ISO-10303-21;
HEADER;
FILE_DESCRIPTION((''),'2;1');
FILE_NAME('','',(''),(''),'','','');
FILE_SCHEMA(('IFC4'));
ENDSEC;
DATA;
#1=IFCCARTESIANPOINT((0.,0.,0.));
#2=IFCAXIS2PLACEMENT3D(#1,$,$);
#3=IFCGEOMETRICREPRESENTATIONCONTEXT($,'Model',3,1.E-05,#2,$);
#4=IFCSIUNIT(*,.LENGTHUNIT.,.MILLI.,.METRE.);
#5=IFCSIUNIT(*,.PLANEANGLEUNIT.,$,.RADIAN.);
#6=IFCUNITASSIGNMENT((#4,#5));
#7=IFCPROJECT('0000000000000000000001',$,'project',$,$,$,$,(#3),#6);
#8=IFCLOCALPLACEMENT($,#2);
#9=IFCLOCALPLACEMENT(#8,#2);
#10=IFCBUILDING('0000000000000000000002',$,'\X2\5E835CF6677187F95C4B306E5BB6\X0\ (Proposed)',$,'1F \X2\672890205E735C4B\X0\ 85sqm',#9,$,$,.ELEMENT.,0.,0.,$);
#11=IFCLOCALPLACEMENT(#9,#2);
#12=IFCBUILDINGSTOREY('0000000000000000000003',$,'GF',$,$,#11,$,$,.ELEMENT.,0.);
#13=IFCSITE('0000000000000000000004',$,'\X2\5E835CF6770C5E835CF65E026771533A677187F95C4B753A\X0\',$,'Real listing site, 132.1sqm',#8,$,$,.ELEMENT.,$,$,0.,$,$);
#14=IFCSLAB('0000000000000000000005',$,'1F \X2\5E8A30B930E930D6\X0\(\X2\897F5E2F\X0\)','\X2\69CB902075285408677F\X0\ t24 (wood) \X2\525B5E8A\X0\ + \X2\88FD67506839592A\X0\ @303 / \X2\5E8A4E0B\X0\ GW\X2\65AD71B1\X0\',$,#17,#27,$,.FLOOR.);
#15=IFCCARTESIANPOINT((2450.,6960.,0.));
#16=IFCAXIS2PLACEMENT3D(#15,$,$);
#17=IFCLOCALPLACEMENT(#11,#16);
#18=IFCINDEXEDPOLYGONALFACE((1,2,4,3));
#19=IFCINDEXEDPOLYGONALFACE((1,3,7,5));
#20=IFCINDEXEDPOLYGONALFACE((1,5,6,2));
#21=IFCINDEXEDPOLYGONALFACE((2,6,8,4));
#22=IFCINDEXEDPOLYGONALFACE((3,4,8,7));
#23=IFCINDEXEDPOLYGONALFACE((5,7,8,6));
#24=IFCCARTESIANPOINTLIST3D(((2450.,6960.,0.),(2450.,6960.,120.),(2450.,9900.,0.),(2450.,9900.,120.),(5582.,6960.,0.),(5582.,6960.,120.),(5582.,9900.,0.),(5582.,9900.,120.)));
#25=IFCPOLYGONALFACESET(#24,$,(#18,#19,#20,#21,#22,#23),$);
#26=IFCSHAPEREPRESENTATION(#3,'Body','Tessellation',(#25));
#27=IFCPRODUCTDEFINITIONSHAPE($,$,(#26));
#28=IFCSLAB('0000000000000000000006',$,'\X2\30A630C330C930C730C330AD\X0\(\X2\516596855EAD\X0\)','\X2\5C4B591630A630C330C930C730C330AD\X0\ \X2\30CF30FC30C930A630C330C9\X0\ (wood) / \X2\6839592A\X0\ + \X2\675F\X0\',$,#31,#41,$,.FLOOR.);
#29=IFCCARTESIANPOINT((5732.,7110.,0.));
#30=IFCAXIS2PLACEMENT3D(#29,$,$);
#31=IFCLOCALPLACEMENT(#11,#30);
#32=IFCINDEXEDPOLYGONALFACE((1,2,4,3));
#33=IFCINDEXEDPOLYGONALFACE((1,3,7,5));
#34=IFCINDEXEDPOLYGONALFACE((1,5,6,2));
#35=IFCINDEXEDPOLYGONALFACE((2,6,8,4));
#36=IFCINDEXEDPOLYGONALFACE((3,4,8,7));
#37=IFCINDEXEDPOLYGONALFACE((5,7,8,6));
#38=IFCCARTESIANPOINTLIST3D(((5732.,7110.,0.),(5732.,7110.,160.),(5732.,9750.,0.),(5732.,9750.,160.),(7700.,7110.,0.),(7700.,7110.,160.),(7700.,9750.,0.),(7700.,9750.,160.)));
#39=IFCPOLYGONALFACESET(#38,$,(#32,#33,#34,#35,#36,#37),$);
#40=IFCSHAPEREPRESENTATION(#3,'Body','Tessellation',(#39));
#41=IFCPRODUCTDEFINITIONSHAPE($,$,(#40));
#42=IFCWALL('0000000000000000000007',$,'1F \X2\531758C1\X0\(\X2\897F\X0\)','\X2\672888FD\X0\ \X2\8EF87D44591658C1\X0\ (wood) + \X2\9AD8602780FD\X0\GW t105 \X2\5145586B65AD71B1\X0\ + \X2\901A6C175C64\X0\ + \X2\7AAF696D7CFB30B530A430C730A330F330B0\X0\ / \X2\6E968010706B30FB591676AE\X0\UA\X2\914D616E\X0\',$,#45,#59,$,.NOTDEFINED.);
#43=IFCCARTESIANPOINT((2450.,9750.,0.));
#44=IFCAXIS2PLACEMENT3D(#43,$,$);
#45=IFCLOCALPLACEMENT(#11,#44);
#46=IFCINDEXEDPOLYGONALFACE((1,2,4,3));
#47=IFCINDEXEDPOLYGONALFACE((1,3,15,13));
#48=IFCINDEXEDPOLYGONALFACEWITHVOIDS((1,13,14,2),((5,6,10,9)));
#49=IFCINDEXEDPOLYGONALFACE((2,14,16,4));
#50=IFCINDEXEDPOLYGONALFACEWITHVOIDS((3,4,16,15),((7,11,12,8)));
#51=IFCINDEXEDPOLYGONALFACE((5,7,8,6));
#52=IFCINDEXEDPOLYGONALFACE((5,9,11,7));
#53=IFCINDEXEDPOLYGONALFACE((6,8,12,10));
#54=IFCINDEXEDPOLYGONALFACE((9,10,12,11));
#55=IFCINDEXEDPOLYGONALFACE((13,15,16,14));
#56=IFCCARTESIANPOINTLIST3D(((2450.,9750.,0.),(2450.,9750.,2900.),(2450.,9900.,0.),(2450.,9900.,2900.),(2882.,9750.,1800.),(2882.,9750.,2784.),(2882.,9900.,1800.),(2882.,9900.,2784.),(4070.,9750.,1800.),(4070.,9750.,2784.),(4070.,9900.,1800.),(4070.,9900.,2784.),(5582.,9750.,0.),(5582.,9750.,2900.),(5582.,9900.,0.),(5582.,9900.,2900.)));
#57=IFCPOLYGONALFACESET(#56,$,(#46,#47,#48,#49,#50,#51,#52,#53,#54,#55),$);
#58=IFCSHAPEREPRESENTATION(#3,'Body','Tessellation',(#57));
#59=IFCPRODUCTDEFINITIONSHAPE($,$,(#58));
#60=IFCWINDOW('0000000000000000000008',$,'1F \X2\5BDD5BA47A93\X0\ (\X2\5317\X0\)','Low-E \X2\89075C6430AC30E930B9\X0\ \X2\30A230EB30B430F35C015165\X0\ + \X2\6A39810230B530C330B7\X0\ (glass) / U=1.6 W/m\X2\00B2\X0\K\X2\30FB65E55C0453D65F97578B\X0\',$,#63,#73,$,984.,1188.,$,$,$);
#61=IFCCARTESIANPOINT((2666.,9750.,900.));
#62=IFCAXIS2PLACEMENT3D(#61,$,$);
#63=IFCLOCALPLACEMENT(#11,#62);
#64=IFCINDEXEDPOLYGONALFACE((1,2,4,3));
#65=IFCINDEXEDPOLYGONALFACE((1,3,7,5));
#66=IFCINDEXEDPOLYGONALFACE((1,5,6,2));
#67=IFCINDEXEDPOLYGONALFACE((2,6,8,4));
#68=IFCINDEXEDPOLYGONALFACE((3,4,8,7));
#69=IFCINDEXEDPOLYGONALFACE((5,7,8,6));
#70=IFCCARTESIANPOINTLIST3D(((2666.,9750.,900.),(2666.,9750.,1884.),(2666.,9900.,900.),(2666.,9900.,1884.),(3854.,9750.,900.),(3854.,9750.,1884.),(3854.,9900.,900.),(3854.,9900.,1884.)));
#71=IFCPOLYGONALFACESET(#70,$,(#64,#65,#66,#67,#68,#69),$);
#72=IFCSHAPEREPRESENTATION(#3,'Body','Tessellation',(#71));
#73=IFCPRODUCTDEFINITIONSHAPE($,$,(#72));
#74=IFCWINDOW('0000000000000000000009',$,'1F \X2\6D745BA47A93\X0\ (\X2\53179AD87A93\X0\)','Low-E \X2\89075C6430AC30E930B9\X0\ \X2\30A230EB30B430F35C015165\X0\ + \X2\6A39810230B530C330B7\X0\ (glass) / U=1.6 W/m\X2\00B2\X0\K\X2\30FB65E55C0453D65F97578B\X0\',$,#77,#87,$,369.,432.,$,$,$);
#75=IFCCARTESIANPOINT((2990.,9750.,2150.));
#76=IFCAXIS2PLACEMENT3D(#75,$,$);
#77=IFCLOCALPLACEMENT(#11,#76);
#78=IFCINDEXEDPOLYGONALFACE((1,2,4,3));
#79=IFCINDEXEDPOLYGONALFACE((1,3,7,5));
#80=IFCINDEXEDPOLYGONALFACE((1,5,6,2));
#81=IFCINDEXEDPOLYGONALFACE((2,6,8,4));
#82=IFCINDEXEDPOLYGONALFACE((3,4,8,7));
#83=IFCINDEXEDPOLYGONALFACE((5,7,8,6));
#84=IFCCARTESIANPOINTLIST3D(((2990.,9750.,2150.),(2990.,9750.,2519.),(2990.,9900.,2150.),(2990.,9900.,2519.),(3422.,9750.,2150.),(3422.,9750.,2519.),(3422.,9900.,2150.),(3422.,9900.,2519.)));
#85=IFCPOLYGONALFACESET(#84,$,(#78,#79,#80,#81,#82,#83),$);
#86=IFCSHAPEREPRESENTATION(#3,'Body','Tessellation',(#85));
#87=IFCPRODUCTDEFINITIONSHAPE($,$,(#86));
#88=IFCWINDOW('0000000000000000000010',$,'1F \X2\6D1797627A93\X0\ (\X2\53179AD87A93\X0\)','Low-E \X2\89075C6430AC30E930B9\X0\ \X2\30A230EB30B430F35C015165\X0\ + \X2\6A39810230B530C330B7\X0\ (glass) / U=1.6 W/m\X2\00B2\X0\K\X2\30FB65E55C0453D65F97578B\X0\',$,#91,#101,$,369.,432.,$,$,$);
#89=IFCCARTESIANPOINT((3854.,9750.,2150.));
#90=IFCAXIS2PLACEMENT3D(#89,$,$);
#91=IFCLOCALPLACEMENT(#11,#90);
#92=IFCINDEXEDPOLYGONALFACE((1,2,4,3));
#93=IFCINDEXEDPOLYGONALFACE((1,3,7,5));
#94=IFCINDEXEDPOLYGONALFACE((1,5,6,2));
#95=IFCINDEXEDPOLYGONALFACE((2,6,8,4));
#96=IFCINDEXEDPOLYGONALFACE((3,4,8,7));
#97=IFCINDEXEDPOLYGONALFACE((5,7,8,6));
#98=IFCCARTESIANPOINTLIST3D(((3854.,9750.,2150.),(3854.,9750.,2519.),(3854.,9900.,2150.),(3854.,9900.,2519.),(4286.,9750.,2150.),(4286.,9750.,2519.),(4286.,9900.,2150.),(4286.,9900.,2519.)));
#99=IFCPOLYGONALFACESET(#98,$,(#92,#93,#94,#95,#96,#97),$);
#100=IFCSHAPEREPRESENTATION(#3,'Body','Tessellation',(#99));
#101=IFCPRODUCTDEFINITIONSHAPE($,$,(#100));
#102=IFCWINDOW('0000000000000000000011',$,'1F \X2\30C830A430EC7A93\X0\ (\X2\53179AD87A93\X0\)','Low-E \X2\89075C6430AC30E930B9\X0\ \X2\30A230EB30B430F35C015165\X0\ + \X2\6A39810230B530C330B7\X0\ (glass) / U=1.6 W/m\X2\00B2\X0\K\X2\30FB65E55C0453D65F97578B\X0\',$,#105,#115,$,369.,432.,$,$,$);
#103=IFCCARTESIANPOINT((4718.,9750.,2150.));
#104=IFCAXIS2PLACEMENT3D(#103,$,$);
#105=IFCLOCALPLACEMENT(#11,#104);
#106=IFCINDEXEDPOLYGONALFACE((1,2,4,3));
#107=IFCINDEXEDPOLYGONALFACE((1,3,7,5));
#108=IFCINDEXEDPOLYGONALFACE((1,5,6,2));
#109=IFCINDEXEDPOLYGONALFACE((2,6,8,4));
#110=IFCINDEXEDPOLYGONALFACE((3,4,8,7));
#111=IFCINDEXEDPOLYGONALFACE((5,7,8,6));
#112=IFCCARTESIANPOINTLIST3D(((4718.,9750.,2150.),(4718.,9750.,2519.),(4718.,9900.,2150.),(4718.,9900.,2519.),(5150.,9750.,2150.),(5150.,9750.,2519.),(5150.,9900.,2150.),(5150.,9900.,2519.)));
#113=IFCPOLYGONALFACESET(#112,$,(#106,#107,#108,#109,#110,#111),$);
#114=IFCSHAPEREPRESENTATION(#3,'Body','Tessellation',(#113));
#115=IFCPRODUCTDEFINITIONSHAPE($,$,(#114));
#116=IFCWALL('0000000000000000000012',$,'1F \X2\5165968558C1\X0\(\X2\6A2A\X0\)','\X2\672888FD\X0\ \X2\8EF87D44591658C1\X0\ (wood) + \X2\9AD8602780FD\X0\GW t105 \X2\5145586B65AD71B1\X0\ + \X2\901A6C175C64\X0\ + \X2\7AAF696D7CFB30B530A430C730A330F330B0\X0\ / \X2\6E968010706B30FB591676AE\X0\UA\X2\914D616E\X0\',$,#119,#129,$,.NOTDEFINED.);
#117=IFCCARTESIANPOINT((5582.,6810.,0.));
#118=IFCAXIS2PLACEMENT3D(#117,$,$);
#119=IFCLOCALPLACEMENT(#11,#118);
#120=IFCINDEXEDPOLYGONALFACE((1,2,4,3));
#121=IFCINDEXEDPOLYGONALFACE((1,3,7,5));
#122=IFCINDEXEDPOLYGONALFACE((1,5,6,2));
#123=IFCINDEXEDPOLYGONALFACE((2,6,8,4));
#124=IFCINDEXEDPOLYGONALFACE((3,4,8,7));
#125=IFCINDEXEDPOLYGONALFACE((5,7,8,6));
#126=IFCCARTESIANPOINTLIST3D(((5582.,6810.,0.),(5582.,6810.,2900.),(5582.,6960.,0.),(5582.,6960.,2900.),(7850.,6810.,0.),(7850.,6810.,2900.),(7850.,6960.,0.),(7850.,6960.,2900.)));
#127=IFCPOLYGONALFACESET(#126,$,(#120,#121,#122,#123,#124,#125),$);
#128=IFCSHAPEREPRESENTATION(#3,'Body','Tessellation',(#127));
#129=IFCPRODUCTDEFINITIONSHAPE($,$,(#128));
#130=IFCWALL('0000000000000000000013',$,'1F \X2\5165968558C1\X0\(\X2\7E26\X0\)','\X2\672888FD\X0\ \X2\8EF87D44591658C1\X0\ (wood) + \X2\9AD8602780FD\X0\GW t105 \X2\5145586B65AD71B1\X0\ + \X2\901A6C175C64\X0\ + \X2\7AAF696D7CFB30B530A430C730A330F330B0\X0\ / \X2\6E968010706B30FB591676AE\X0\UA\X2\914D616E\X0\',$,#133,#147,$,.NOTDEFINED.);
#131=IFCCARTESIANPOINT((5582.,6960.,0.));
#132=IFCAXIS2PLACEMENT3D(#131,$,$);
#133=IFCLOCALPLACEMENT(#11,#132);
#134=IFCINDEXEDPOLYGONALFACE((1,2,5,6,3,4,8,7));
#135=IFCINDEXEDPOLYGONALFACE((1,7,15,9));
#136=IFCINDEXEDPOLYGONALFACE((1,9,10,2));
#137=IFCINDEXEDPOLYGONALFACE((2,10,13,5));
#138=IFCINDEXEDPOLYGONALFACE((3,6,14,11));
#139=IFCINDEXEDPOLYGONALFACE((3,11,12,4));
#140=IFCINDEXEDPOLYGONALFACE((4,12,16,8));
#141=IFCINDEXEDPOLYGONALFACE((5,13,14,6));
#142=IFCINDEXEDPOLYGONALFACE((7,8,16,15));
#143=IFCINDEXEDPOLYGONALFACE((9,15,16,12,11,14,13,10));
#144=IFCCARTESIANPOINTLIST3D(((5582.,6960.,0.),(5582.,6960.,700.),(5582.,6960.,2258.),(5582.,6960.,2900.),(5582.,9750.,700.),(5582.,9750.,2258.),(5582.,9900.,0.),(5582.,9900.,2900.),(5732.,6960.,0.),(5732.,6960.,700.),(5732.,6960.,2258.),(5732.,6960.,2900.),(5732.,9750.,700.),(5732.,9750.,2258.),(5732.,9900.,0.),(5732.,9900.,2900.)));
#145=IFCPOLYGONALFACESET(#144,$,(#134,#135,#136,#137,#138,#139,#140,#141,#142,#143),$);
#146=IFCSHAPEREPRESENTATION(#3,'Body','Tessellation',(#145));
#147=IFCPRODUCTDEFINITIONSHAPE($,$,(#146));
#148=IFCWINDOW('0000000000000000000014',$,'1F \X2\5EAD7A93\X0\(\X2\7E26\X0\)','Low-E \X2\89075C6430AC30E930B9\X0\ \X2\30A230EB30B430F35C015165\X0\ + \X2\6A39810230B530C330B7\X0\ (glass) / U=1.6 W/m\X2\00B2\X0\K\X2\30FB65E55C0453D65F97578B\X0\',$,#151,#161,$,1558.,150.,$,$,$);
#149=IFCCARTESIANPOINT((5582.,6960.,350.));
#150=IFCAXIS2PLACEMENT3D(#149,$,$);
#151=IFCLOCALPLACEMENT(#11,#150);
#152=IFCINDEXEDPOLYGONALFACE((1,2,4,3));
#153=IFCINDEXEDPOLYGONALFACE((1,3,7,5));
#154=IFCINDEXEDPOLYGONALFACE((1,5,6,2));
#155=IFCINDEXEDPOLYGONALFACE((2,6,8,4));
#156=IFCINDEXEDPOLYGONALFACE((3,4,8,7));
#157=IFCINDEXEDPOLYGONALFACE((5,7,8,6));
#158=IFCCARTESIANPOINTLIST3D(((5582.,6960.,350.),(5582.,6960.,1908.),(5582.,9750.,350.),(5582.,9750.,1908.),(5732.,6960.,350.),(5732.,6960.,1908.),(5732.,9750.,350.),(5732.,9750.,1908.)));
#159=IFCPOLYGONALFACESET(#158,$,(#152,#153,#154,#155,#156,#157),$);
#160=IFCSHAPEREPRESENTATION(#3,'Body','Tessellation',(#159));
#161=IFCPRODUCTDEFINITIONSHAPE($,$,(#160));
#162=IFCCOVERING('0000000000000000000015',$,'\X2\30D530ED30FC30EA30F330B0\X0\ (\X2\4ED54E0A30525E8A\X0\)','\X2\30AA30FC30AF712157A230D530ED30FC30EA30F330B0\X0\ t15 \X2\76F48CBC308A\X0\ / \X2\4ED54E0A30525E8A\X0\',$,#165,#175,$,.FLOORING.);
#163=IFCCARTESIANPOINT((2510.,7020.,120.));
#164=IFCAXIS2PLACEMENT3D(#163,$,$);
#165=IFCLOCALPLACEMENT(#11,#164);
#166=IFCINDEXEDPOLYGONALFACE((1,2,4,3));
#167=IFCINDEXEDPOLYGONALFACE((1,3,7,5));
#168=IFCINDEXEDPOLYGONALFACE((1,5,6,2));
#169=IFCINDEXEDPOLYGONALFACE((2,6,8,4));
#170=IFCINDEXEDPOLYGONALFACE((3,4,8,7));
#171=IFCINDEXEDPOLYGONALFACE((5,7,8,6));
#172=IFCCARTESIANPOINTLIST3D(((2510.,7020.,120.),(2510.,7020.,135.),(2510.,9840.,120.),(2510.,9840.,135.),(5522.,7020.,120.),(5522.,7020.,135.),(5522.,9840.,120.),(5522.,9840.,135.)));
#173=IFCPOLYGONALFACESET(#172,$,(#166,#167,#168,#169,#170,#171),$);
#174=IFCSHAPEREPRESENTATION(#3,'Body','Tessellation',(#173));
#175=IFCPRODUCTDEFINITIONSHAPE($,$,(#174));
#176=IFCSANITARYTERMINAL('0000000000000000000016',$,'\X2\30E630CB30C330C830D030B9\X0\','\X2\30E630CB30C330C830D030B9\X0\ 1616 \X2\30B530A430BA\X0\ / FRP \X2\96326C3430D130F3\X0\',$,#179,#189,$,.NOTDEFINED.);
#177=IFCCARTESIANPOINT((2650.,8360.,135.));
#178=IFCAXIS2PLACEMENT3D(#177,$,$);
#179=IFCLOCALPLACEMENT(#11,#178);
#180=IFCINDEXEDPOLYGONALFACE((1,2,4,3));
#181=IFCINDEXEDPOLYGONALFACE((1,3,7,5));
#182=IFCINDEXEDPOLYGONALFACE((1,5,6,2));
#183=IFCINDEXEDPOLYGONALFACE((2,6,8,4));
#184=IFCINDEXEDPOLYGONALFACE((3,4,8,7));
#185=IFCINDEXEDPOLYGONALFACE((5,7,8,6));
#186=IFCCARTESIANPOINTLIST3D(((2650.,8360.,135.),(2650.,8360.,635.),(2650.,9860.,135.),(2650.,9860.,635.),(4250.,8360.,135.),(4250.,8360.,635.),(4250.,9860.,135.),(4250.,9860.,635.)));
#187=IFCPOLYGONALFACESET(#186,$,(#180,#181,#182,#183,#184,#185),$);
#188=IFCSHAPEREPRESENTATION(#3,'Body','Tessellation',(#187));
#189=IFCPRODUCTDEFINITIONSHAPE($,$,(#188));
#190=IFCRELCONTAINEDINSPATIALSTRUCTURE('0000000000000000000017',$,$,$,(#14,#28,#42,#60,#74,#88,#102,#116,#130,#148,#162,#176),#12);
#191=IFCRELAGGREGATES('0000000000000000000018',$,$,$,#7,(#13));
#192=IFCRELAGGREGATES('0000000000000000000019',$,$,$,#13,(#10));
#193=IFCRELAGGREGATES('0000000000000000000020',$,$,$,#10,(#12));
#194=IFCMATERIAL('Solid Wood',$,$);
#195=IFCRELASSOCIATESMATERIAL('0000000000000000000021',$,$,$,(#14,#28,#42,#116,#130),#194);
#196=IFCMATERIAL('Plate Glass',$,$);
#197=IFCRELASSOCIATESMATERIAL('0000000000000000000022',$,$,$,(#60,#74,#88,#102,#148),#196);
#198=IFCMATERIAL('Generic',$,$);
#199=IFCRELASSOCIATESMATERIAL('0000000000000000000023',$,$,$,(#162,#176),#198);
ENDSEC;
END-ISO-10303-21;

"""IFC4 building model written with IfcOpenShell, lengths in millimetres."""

from ifc_helpers import new_model, si_unit, frame, frame_2d, origin, place, context, project, spatial, rectangle, extrude, material, element, fill, save


model = new_model("IFC4")

# Units and contexts
model_context = context("Model", 3, precision=1e-05, world=origin())
ifc_project = project(units=[si_unit("LENGTHUNIT", "METRE", prefix="MILLI"), si_unit("PLANEANGLEUNIT", "RADIAN")], contexts=[model_context])

# Site, building, storey
site_placement = place(None, origin())
site = spatial("IfcSite", under=ifc_project, at=site_placement, Name="広島県広島市東区東蟹屋町", ObjectType="Real listing site, 132.1sqm", CompositionType="ELEMENT", RefElevation=0.0)
building_placement = place(site_placement, origin())
building = spatial("IfcBuilding", under=site, at=building_placement, Name="広島東蟹屋の家 (Proposed)", ObjectType="1F 木造平屋 85sqm", CompositionType="ELEMENT", ElevationOfRefHeight=0.0, ElevationOfTerrain=0.0)
storey_placement = place(building_placement, origin())
storey = spatial("IfcBuildingStorey", under=building, at=storey_placement, Name="GF", CompositionType="ELEMENT", Elevation=0.0)

# Slabs
ifc_material_1 = material(Name="Solid Wood")
slab_1_placement = place(storey_placement, frame((2450.0, 6960.0, 0.0)))
element("IfcSlab", 1, at=slab_1_placement, inside=storey, material=ifc_material_1, Name="1F 床スラブ(西帯)", Description="構造用合板 t24 (wood) 剛床 + 製材根太 @303 / 床下 GW断熱", PredefinedType="FLOOR", context=model_context, shape_type="SweptSolid", body=[
    extrude(rectangle(XDim=3132.0, YDim=2940.0, at=frame_2d((1566.0, 1470.0))), frame((2450.0, 6960.0, 0.0)), (0.0, 0.0, 1.0), 120.0),
])
slab_2_placement = place(storey_placement, frame((5732.0, 7110.0, 0.0)))
element("IfcSlab", 2, at=slab_2_placement, inside=storey, material=ifc_material_1, Name="ウッドデッキ(入隅庭)", Description="屋外ウッドデッキ ハードウッド (wood) / 根太 + 束", PredefinedType="FLOOR", context=model_context, shape_type="SweptSolid", body=[
    extrude(rectangle(XDim=1968.0, YDim=2640.0, at=frame_2d((984.0, 1320.0))), frame((5732.0, 7110.0, 0.0)), (0.0, 0.0, 1.0), 160.0),
])

# Wall, openings, windows
wall_1_placement = place(storey_placement, frame((2450.0, 9750.0, 0.0)))
wall_1 = element("IfcWall", 3, at=wall_1_placement, inside=storey, material=ifc_material_1, Name="1F 北壁(西)", Description="木製 軸組外壁 (wood) + 高性能GW t105 充填断熱 + 通気層 + 窯業系サイディング / 準耐火・外皮UA配慮", PredefinedType="NOTDEFINED", context=model_context, shape_type="SweptSolid", body=[
    extrude(rectangle(XDim=3132.0, YDim=150.0, at=frame_2d((1566.0, 75.0))), frame((2450.0, 9750.0, 0.0)), (0.0, 0.0, 1.0), 2900.0),
])
opening_1_placement = place(storey_placement, frame((2666.0, 9750.0, 900.0)))
opening_1 = element("IfcOpeningElement", 4, at=opening_1_placement, cuts=wall_1, PredefinedType="NOTDEFINED", context=model_context, shape_type="SweptSolid", body=[
    extrude(rectangle(XDim=1188.0, YDim=150.0, at=frame_2d((594.0, 75.0))), frame((2666.0, 9750.0, 900.0)), (0.0, 0.0, 1.0), 984.0),
])
opening_2_placement = place(storey_placement, frame((2990.0, 9750.0, 2150.0)))
opening_2 = element("IfcOpeningElement", 5, at=opening_2_placement, cuts=wall_1, PredefinedType="NOTDEFINED", context=model_context, shape_type="SweptSolid", body=[
    extrude(rectangle(XDim=432.0, YDim=150.0, at=frame_2d((216.0, 75.0))), frame((2990.0, 9750.0, 2150.0)), (0.0, 0.0, 1.0), 369.0),
])
opening_3_placement = place(storey_placement, frame((3854.0, 9750.0, 2150.0)))
opening_3 = element("IfcOpeningElement", 6, at=opening_3_placement, cuts=wall_1, PredefinedType="NOTDEFINED", context=model_context, shape_type="SweptSolid", body=[
    extrude(rectangle(XDim=432.0, YDim=150.0, at=frame_2d((216.0, 75.0))), frame((3854.0, 9750.0, 2150.0)), (0.0, 0.0, 1.0), 369.0),
])
opening_4_placement = place(storey_placement, frame((4718.0, 9750.0, 2150.0)))
opening_4 = element("IfcOpeningElement", 7, at=opening_4_placement, cuts=wall_1, PredefinedType="NOTDEFINED", context=model_context, shape_type="SweptSolid", body=[
    extrude(rectangle(XDim=432.0, YDim=150.0, at=frame_2d((216.0, 75.0))), frame((4718.0, 9750.0, 2150.0)), (0.0, 0.0, 1.0), 369.0),
])
ifc_material_2 = material(Name="Plate Glass")
window_1_placement = place(storey_placement, frame((2666.0, 9750.0, 900.0)))
window_1 = element("IfcWindow", 8, at=window_1_placement, inside=storey, material=ifc_material_2, Name="1F 寝室窓 (北)", Description="Low-E 複層ガラス アルゴン封入 + 樹脂サッシ (glass) / U=1.6 W/m²K・日射取得型", OverallHeight=984.0, OverallWidth=1188.0, context=model_context, shape_type="SweptSolid", body=[
    extrude(rectangle(XDim=1188.0, YDim=150.0, at=frame_2d((594.0, 75.0))), frame((2666.0, 9750.0, 900.0)), (0.0, 0.0, 1.0), 984.0),
])
fill(opening_1, window_1)
window_2_placement = place(storey_placement, frame((2990.0, 9750.0, 2150.0)))
window_2 = element("IfcWindow", 9, at=window_2_placement, inside=storey, material=ifc_material_2, Name="1F 浴室窓 (北高窓)", Description="Low-E 複層ガラス アルゴン封入 + 樹脂サッシ (glass) / U=1.6 W/m²K・日射取得型", OverallHeight=369.0, OverallWidth=432.0, context=model_context, shape_type="SweptSolid", body=[
    extrude(rectangle(XDim=432.0, YDim=150.0, at=frame_2d((216.0, 75.0))), frame((2990.0, 9750.0, 2150.0)), (0.0, 0.0, 1.0), 369.0),
])
fill(opening_2, window_2)
window_3_placement = place(storey_placement, frame((3854.0, 9750.0, 2150.0)))
window_3 = element("IfcWindow", 10, at=window_3_placement, inside=storey, material=ifc_material_2, Name="1F 洗面窓 (北高窓)", Description="Low-E 複層ガラス アルゴン封入 + 樹脂サッシ (glass) / U=1.6 W/m²K・日射取得型", OverallHeight=369.0, OverallWidth=432.0, context=model_context, shape_type="SweptSolid", body=[
    extrude(rectangle(XDim=432.0, YDim=150.0, at=frame_2d((216.0, 75.0))), frame((3854.0, 9750.0, 2150.0)), (0.0, 0.0, 1.0), 369.0),
])
fill(opening_3, window_3)
window_4_placement = place(storey_placement, frame((4718.0, 9750.0, 2150.0)))
window_4 = element("IfcWindow", 11, at=window_4_placement, inside=storey, material=ifc_material_2, Name="1F トイレ窓 (北高窓)", Description="Low-E 複層ガラス アルゴン封入 + 樹脂サッシ (glass) / U=1.6 W/m²K・日射取得型", OverallHeight=369.0, OverallWidth=432.0, context=model_context, shape_type="SweptSolid", body=[
    extrude(rectangle(XDim=432.0, YDim=150.0, at=frame_2d((216.0, 75.0))), frame((4718.0, 9750.0, 2150.0)), (0.0, 0.0, 1.0), 369.0),
])
fill(opening_4, window_4)

# Wall
wall_2_placement = place(storey_placement, frame((5582.0, 6810.0, 0.0)))
element("IfcWall", 12, at=wall_2_placement, inside=storey, material=ifc_material_1, Name="1F 入隅壁(横)", Description="木製 軸組外壁 (wood) + 高性能GW t105 充填断熱 + 通気層 + 窯業系サイディング / 準耐火・外皮UA配慮", PredefinedType="NOTDEFINED", context=model_context, shape_type="SweptSolid", body=[
    extrude(rectangle(XDim=2268.0, YDim=150.0, at=frame_2d((1134.0, 75.0))), frame((5582.0, 6810.0, 0.0)), (0.0, 0.0, 1.0), 2900.0),
])

# Wall, opening, window
wall_3_placement = place(storey_placement, frame((5582.0, 6960.0, 0.0)))
wall_3 = element("IfcWall", 13, at=wall_3_placement, inside=storey, material=ifc_material_1, Name="1F 入隅壁(縦)", Description="木製 軸組外壁 (wood) + 高性能GW t105 充填断熱 + 通気層 + 窯業系サイディング / 準耐火・外皮UA配慮", PredefinedType="NOTDEFINED", context=model_context, shape_type="SweptSolid", body=[
    extrude(rectangle(XDim=150.0, YDim=2940.0, at=frame_2d((75.0, 1470.0))), frame((5582.0, 6960.0, 0.0)), (0.0, 0.0, 1.0), 2900.0),
])
opening_5_placement = place(storey_placement, frame((5582.0, 6960.0, 350.0)))
opening_5 = element("IfcOpeningElement", 14, at=opening_5_placement, cuts=wall_3, PredefinedType="NOTDEFINED", context=model_context, shape_type="SweptSolid", body=[
    extrude(rectangle(XDim=150.0, YDim=2790.0, at=frame_2d((75.0, 1395.0))), frame((5582.0, 6960.0, 350.0)), (0.0, 0.0, 1.0), 1558.0),
])
window_5_placement = place(storey_placement, frame((5582.0, 6960.0, 350.0)))
window_5 = element("IfcWindow", 15, at=window_5_placement, inside=storey, material=ifc_material_2, Name="1F 庭窓(縦)", Description="Low-E 複層ガラス アルゴン封入 + 樹脂サッシ (glass) / U=1.6 W/m²K・日射取得型", OverallHeight=1558.0, OverallWidth=150.0, context=model_context, shape_type="SweptSolid", body=[
    extrude(rectangle(XDim=150.0, YDim=2790.0, at=frame_2d((75.0, 1395.0))), frame((5582.0, 6960.0, 350.0)), (0.0, 0.0, 1.0), 1558.0),
])
fill(opening_5, window_5)

# Covering
ifc_material_3 = material(Name="Generic")
covering_placement = place(storey_placement, frame((2510.0, 7020.0, 120.0)))
element("IfcCovering", 16, at=covering_placement, inside=storey, material=ifc_material_3, Name="フローリング (仕上げ床)", Description="オーク無垢フローリング t15 直貼り / 仕上げ床", PredefinedType="FLOORING", context=model_context, shape_type="SweptSolid", body=[
    extrude(rectangle(XDim=3012.0, YDim=2820.0, at=frame_2d((1506.0, 1410.0))), frame((2510.0, 7020.0, 120.0)), (0.0, 0.0, 1.0), 15.0),
])

# Sanitary terminal
sanitary_terminal_1_placement = place(storey_placement, frame((2650.0, 8360.0, 135.0)))
element("IfcSanitaryTerminal", 17, at=sanitary_terminal_1_placement, inside=storey, material=ifc_material_3, Name="ユニットバス", Description="ユニットバス 1616 サイズ / FRP 防水パン", PredefinedType="NOTDEFINED", context=model_context, shape_type="SweptSolid", body=[
    extrude(rectangle(XDim=1600.0, YDim=1500.0, at=frame_2d((800.0, 750.0))), frame((2650.0, 8360.0, 135.0)), (0.0, 0.0, 1.0), 500.0),
])

save(model, "model.ifc")
